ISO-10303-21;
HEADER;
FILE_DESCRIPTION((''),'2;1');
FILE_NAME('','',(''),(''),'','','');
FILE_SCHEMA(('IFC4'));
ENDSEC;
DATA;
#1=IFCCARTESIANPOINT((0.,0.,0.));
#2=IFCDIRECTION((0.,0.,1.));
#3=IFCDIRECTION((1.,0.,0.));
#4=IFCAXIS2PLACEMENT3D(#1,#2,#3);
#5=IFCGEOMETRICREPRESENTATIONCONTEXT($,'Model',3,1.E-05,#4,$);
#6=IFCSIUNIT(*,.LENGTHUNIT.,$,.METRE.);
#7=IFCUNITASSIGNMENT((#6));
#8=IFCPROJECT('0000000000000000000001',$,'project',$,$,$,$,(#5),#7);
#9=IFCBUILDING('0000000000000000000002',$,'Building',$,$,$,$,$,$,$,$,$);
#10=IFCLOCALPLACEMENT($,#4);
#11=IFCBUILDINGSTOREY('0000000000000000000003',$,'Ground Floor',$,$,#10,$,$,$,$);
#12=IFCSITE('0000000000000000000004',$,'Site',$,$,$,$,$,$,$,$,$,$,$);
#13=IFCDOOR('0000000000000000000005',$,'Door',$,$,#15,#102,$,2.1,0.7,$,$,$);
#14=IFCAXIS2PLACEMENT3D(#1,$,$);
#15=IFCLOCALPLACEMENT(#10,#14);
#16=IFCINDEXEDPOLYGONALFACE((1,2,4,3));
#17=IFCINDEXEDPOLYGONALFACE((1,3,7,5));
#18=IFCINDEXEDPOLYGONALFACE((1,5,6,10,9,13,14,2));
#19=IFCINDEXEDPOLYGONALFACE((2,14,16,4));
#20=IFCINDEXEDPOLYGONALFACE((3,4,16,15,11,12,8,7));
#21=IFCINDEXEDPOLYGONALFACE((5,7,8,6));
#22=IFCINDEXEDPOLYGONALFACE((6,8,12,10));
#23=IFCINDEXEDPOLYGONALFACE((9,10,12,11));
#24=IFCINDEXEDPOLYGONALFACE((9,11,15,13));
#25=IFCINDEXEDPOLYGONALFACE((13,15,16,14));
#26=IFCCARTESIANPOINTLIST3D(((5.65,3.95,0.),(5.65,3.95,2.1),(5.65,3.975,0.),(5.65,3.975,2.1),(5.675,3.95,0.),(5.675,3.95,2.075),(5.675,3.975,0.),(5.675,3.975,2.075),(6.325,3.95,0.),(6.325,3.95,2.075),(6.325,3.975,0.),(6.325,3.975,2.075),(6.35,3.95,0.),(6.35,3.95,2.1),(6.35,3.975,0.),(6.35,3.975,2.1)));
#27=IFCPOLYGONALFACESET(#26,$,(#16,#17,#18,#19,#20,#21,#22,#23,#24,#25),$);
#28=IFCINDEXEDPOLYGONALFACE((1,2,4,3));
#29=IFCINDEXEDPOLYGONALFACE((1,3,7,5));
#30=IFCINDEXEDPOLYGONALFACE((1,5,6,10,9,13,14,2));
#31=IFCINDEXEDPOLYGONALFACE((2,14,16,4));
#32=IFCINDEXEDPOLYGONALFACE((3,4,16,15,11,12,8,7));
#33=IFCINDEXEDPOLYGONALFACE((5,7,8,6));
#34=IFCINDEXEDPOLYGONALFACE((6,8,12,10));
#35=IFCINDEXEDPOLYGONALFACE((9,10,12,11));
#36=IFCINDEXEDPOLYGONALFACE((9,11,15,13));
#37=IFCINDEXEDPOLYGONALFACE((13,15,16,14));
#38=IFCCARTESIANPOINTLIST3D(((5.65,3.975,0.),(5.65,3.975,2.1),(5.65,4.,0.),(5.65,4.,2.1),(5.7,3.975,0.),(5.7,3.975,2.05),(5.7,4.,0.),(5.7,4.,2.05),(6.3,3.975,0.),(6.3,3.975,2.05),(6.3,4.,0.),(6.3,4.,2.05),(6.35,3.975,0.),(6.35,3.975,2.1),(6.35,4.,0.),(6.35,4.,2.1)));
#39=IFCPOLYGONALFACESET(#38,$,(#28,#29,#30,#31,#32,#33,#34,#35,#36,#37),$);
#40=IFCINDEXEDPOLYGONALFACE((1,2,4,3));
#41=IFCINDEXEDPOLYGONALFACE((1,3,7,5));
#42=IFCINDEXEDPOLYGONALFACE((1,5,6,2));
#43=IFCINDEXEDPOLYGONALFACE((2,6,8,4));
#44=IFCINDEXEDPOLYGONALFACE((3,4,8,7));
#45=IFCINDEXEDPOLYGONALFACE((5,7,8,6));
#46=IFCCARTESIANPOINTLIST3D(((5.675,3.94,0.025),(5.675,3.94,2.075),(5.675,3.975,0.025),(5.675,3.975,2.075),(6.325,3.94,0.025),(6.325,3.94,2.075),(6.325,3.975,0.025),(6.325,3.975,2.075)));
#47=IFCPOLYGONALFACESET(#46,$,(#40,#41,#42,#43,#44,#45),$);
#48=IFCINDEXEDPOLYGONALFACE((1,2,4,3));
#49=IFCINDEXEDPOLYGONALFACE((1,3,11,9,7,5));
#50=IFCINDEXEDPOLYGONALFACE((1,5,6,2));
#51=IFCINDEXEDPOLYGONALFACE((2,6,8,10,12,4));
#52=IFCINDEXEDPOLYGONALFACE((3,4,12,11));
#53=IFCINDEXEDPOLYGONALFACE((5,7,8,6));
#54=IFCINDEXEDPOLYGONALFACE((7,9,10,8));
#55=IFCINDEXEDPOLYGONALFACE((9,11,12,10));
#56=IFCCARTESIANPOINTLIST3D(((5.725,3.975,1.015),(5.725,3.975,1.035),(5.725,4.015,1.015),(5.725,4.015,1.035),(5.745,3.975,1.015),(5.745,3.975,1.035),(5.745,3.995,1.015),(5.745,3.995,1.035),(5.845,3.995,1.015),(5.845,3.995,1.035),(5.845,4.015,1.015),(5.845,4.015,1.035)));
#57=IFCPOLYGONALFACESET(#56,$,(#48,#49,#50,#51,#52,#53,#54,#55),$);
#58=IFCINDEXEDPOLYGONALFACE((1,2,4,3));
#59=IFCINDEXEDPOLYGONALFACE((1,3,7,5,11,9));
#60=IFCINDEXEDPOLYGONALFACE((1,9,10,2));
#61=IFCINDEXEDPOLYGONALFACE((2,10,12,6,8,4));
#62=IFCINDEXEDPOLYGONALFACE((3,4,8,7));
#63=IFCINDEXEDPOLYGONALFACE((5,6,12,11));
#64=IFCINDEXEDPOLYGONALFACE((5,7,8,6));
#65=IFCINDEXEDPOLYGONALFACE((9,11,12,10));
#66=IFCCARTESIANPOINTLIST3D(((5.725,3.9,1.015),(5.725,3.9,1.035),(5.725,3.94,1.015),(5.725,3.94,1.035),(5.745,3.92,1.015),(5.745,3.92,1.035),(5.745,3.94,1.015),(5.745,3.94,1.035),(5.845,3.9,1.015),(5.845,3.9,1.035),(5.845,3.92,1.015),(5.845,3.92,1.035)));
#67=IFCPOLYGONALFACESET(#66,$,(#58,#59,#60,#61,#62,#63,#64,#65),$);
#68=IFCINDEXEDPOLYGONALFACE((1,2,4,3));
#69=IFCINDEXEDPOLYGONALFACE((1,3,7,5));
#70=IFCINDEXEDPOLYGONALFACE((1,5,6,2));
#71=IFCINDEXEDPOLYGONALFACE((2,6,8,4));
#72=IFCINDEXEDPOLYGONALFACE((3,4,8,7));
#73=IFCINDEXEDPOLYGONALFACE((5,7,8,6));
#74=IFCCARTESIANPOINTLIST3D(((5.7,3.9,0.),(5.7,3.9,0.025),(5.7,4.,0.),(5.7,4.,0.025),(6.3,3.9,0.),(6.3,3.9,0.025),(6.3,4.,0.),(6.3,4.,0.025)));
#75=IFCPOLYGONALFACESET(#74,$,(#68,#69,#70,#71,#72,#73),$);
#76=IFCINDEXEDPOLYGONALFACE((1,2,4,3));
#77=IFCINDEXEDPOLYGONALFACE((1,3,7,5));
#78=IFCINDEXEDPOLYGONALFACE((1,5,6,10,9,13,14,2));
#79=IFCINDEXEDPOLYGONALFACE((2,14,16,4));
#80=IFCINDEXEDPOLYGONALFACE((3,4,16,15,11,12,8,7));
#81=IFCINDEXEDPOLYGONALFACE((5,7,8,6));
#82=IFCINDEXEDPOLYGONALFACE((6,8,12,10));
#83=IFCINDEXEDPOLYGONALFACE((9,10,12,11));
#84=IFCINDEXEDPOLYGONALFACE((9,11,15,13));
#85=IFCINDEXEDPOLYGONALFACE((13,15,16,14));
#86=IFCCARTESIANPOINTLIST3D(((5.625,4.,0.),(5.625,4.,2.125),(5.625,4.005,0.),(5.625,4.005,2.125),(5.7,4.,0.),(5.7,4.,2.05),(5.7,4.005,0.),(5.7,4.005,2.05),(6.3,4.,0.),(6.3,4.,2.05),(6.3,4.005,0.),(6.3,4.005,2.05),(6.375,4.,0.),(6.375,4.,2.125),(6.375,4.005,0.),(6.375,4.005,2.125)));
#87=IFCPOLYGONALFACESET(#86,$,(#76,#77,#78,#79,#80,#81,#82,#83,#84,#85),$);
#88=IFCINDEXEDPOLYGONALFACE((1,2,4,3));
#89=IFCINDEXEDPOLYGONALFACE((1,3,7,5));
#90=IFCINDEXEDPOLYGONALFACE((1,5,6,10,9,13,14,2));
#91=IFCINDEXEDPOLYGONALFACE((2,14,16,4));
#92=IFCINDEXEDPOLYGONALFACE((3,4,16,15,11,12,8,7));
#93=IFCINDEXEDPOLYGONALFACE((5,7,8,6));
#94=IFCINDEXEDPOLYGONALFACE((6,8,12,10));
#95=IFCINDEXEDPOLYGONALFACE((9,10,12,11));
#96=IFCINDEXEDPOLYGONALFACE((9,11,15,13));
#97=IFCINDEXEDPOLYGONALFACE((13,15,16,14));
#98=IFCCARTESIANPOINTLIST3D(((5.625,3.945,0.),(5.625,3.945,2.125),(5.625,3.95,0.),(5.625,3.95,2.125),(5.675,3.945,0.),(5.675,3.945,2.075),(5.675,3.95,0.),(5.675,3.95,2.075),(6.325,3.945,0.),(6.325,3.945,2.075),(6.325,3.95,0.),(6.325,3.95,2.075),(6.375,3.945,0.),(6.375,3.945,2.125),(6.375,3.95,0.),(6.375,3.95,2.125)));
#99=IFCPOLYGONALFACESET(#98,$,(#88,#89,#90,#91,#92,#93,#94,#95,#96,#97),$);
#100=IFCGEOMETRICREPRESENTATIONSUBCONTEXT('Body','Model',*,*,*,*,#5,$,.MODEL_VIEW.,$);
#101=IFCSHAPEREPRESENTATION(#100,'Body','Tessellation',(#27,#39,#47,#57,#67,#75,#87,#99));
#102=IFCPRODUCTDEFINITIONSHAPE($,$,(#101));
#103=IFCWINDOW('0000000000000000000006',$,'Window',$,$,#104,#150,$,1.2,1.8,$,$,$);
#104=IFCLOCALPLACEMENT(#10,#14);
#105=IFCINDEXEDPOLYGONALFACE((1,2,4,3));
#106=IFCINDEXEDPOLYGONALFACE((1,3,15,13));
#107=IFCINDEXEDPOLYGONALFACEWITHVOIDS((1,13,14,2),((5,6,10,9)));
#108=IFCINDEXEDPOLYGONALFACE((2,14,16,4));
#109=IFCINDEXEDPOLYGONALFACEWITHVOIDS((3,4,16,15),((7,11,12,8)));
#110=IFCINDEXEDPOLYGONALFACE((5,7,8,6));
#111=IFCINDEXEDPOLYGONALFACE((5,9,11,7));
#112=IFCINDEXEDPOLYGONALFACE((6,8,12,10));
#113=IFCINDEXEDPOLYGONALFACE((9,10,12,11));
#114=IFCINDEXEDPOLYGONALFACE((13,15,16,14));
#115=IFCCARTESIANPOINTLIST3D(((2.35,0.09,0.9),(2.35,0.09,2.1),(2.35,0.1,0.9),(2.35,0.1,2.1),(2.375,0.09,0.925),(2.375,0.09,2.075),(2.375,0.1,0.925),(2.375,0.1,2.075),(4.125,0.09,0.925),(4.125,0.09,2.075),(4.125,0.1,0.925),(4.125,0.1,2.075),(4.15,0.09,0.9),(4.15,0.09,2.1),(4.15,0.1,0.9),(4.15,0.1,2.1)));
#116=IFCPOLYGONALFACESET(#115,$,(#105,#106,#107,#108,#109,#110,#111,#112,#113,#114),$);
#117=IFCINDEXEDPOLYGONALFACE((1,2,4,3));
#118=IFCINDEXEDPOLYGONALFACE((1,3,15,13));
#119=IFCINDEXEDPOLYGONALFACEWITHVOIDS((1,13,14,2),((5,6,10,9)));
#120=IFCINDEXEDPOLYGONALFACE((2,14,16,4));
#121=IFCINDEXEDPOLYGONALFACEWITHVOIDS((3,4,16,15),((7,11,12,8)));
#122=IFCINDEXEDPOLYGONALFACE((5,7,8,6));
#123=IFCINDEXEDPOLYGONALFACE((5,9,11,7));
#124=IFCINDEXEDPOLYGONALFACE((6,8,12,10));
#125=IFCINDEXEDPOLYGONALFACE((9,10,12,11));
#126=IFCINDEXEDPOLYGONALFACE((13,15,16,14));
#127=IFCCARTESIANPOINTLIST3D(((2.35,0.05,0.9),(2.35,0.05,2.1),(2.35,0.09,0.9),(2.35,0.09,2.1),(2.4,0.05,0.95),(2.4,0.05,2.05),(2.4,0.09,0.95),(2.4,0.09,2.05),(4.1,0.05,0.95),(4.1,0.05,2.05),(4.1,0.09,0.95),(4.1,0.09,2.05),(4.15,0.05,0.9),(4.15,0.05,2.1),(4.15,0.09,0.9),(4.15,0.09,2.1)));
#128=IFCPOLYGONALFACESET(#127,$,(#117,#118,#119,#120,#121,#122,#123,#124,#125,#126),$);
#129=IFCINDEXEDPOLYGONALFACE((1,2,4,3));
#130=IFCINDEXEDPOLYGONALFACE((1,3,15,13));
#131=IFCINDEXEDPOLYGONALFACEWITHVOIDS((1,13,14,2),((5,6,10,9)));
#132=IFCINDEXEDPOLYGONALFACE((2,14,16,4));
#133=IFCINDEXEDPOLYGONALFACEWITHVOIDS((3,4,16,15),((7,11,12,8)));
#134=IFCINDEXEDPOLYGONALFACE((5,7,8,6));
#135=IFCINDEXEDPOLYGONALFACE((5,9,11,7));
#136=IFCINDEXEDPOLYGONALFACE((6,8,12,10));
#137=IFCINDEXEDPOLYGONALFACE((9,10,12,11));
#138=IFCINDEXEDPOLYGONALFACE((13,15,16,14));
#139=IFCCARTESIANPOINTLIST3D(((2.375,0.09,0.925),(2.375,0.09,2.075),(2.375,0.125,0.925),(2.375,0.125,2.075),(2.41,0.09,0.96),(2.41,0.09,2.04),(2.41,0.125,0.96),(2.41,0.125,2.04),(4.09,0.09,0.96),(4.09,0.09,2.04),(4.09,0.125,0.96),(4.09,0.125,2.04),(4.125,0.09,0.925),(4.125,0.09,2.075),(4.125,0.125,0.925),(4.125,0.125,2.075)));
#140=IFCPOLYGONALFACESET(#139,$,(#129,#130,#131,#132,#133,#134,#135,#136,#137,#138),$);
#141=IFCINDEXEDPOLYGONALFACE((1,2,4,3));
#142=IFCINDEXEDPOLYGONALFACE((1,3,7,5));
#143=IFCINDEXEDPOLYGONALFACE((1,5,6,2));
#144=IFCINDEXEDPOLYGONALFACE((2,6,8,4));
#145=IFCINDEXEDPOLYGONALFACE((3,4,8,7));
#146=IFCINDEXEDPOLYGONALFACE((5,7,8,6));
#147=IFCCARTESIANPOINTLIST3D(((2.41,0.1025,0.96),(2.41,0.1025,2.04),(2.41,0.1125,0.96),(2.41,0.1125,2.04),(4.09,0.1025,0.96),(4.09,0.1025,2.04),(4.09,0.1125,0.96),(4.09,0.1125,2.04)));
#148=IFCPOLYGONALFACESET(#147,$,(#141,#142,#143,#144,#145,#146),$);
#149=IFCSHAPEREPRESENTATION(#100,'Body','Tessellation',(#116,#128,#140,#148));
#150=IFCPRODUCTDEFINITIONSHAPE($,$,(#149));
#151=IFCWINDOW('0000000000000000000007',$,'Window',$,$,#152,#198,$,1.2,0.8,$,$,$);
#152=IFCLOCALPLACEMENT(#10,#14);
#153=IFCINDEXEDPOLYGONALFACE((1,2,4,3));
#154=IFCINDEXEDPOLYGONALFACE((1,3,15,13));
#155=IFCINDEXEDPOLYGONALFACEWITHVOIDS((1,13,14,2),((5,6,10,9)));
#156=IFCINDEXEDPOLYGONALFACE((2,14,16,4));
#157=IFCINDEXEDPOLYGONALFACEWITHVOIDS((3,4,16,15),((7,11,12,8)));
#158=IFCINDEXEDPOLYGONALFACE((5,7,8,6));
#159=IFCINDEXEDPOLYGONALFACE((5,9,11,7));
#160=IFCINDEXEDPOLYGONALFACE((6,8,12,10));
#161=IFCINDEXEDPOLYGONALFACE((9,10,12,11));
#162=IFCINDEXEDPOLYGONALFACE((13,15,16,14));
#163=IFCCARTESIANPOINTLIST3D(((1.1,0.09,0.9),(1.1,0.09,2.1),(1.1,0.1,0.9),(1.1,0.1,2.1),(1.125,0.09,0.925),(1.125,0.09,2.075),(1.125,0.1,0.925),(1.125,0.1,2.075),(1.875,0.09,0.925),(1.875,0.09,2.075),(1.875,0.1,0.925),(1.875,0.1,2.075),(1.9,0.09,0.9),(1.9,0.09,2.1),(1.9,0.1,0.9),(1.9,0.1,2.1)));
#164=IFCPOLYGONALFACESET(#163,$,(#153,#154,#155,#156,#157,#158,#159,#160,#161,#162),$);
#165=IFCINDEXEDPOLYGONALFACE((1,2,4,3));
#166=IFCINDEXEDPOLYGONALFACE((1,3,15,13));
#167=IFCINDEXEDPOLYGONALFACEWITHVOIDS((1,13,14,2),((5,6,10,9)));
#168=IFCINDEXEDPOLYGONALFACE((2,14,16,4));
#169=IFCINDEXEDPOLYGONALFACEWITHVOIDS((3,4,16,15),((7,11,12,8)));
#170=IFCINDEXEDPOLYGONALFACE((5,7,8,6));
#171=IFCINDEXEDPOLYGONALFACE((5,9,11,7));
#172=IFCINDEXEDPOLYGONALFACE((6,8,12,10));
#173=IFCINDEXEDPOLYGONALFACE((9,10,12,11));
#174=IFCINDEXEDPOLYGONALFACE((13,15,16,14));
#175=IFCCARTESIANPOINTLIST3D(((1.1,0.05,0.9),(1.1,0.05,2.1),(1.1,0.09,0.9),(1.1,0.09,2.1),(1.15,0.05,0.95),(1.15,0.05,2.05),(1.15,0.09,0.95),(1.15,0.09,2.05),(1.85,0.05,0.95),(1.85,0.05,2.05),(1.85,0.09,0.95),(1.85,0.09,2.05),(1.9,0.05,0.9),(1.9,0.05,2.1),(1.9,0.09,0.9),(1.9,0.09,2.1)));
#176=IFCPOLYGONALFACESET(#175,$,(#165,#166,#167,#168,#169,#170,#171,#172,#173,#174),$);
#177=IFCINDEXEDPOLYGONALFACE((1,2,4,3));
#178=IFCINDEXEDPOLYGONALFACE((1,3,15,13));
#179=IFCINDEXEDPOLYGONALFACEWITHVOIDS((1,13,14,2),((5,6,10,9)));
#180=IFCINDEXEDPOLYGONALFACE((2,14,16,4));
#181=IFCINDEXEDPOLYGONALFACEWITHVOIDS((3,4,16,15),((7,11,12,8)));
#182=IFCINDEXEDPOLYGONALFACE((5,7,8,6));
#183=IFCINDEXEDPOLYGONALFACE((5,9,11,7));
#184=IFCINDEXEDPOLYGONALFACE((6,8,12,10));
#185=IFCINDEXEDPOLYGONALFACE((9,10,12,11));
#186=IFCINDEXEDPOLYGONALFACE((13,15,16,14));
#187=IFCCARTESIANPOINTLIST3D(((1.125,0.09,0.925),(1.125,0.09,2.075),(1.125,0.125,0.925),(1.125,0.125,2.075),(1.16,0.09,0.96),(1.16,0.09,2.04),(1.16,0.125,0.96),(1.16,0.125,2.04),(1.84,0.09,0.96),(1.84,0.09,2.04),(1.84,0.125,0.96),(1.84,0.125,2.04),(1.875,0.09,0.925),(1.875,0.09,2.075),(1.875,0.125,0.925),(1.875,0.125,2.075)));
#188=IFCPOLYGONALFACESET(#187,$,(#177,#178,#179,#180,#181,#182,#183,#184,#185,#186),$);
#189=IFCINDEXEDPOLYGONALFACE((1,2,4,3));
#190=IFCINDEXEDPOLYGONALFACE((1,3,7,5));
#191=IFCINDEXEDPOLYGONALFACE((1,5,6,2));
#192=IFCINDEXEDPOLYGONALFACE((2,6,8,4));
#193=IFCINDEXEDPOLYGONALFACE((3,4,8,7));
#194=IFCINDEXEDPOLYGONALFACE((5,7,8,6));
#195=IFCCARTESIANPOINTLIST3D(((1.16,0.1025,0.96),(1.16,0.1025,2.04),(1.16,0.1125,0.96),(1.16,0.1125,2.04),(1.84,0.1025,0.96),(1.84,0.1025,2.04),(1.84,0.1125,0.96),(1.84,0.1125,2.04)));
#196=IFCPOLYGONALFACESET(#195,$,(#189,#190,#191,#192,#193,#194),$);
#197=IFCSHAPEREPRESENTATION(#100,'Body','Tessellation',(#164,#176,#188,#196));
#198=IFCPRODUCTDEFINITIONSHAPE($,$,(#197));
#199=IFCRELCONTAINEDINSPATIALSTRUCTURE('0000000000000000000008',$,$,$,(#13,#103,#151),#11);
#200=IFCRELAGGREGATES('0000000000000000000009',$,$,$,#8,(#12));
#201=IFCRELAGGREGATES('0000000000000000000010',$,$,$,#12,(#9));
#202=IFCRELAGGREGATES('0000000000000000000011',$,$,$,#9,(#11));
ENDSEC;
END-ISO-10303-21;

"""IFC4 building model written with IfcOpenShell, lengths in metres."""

from ifc_helpers import new_model, si_unit, frame, origin_with_axes, place, context, subcontext, project, spatial, line, indexed_curve, outline, extrude, element, save


model = new_model("IFC4")

# Units and contexts
model_context = context("Model", 3, precision=1e-05, world=origin_with_axes())
body_context = subcontext(model_context, "Body", "Model", "MODEL_VIEW")
ifc_project = project(units=[si_unit("LENGTHUNIT", "METRE")], contexts=[model_context])

# Site, building, storey
site = spatial("IfcSite", under=ifc_project, Name="Site")
building = spatial("IfcBuilding", under=site, Name="Building")
storey_placement = place(None, origin_with_axes())
storey = spatial("IfcBuildingStorey", under=building, at=storey_placement, Name="Ground Floor")

# Door
door_1_placement = place(storey_placement, frame((6.35, 4.0, 0.0), z_axis=(0.0, 0.0, 1.0), x_axis=(-1.0, 0.0, 0.0)))
element("IfcDoor", 1, at=door_1_placement, inside=storey, Name="Door", OverallHeight=2.1, OverallWidth=0.7, context=body_context, shape_type="SweptSolid", body=[
    extrude(outline(indexed_curve([(0.0, 0.0), (0.0, 2.1), (0.7, 2.1), (0.7, 0.0), (0.675, 0.0), (0.675, 2.075), (0.025, 2.075), (0.025, 0.0)], segments=[line(1, 2, 3, 4, 5, 6, 7, 8, 1)])), frame((0.0, 0.025, 0.0), z_axis=(0.0, -1.0, 0.0), x_axis=(1.0, 0.0, 0.0)), (0.0, 0.0, -1.0), 0.025),
    extrude(outline(indexed_curve([(0.0, 0.0), (0.0, 2.1), (0.7, 2.1), (0.7, 0.0), (0.65, 0.0), (0.65, 2.05), (0.05, 2.05), (0.05, 0.0)], segments=[line(1, 2, 3, 4, 5, 6, 7, 8, 1)])), frame((0.0, 0.0, 0.0), z_axis=(0.0, -1.0, 0.0), x_axis=(1.0, 0.0, 0.0)), (0.0, 0.0, -1.0), 0.025),
    extrude(outline(indexed_curve([(0.0, 0.0), (0.65, 0.0), (0.65, 0.035), (0.0, 0.035)], segments=[line(1, 2, 3, 4, 1)])), frame((0.025, 0.025, 0.025), z_axis=(0.0, 0.0, 1.0), x_axis=(1.0, 0.0, 0.0)), (0.0, 0.0, 1.0), 2.05),
    extrude(outline(indexed_curve([(0.0, 0.0), (0.0, -0.04), (-0.12, -0.04), (-0.12, -0.02), (-0.02, -0.02), (-0.02, 0.0)], segments=[line(1, 2, 3, 4, 5, 6, 1)])), frame((0.625, 0.025, 1.015), z_axis=(0.0, 0.0, 1.0), x_axis=(1.0, 0.0, 0.0)), (0.0, 0.0, 1.0), 0.02),
    extrude(outline(indexed_curve([(0.0, 0.0), (0.0, 0.04), (-0.12, 0.04), (-0.12, 0.02), (-0.02, 0.02), (-0.02, 0.0)], segments=[line(1, 2, 3, 4, 5, 6, 1)])), frame((0.625, 0.06, 1.015), z_axis=(0.0, 0.0, 1.0), x_axis=(1.0, 0.0, 0.0)), (0.0, 0.0, 1.0), 0.02),
    extrude(outline(indexed_curve([(0.0, 0.0), (0.6, 0.0), (0.6, 0.1), (0.0, 0.1)], segments=[line(1, 2, 3, 4, 1)])), frame((0.05, 0.0, 0.0), z_axis=(0.0, 0.0, 1.0), x_axis=(1.0, 0.0, 0.0)), (0.0, 0.0, 1.0), 0.025),
    extrude(outline(indexed_curve([(0.0, 0.0), (0.0, 2.125), (0.75, 2.125), (0.75, 0.0), (0.675, 0.0), (0.675, 2.05), (0.075, 2.05), (0.075, 0.0)], segments=[line(1, 2, 3, 4, 5, 6, 7, 8, 1)])), frame((-0.025, -0.005, 0.0), z_axis=(0.0, -1.0, 0.0), x_axis=(1.0, 0.0, 0.0)), (0.0, 0.0, -1.0), 0.005),
    extrude(outline(indexed_curve([(0.0, 0.0), (0.0, 2.125), (0.75, 2.125), (0.75, 0.0), (0.7, 0.0), (0.7, 2.075), (0.05, 2.075), (0.05, 0.0)], segments=[line(1, 2, 3, 4, 5, 6, 7, 8, 1)])), frame((-0.025, 0.05, 0.0), z_axis=(0.0, -1.0, 0.0), x_axis=(1.0, 0.0, 0.0)), (0.0, 0.0, -1.0), 0.005),
])

# Windows
window_1_placement = place(storey_placement, frame((2.35, 0.0, 0.9), z_axis=(0.0, 0.0, 1.0), x_axis=(1.0, 0.0, 0.0)))
element("IfcWindow", 2, at=window_1_placement, inside=storey, Name="Window", OverallHeight=1.2, OverallWidth=1.8, context=body_context, shape_type="SweptSolid", body=[
    extrude(outline(indexed_curve([(0.0, 0.0), (1.8, 0.0), (1.8, 1.2), (0.0, 1.2)], segments=[line(1, 2, 3, 4, 1)]), holes=[indexed_curve([(0.025, 0.025), (1.775, 0.025), (1.775, 1.175), (0.025, 1.175)], segments=[line(1, 2, 3, 4, 1)])]), frame((0.0, 0.09, 0.0), z_axis=(0.0, -1.0, 0.0), x_axis=(1.0, 0.0, 0.0)), (0.0, 0.0, -1.0), 0.01),
    extrude(outline(indexed_curve([(0.0, 0.0), (1.8, 0.0), (1.8, 1.2), (0.0, 1.2)], segments=[line(1, 2, 3, 4, 1)]), holes=[indexed_curve([(0.05, 0.05), (1.75, 0.05), (1.75, 1.15), (0.05, 1.15)], segments=[line(1, 2, 3, 4, 1)])]), frame((0.0, 0.05, 0.0), z_axis=(0.0, -1.0, 0.0), x_axis=(1.0, 0.0, 0.0)), (0.0, 0.0, -1.0), 0.04),
    extrude(outline(indexed_curve([(0.0, 0.0), (1.75, 0.0), (1.75, 1.15), (0.0, 1.15)], segments=[line(1, 2, 3, 4, 1)]), holes=[indexed_curve([(0.035, 0.035), (1.715, 0.035), (1.715, 1.115), (0.035, 1.115)], segments=[line(1, 2, 3, 4, 1)])]), frame((0.025, 0.09, 0.025), z_axis=(0.0, -1.0, 0.0), x_axis=(1.0, 0.0, 0.0)), (0.0, 0.0, -1.0), 0.035),
    extrude(outline(indexed_curve([(0.035, 0.035), (1.715, 0.035), (1.715, 1.115), (0.035, 1.115)], segments=[line(1, 2, 3, 4, 1)])), frame((0.025, 0.1025, 0.025), z_axis=(0.0, -1.0, 0.0), x_axis=(1.0, 0.0, 0.0)), (0.0, 0.0, -1.0), 0.01),
])
window_2_placement = place(storey_placement, frame((1.1, 0.0, 0.9), z_axis=(0.0, 0.0, 1.0), x_axis=(1.0, 0.0, 0.0)))
element("IfcWindow", 3, at=window_2_placement, inside=storey, Name="Window", OverallHeight=1.2, OverallWidth=0.8, context=body_context, shape_type="SweptSolid", body=[
    extrude(outline(indexed_curve([(0.0, 0.0), (0.8, 0.0), (0.8, 1.2), (0.0, 1.2)], segments=[line(1, 2, 3, 4, 1)]), holes=[indexed_curve([(0.025, 0.025), (0.775, 0.025), (0.775, 1.175), (0.025, 1.175)], segments=[line(1, 2, 3, 4, 1)])]), frame((0.0, 0.09, 0.0), z_axis=(0.0, -1.0, 0.0), x_axis=(1.0, 0.0, 0.0)), (0.0, 0.0, -1.0), 0.01),
    extrude(outline(indexed_curve([(0.0, 0.0), (0.8, 0.0), (0.8, 1.2), (0.0, 1.2)], segments=[line(1, 2, 3, 4, 1)]), holes=[indexed_curve([(0.05, 0.05), (0.75, 0.05), (0.75, 1.15), (0.05, 1.15)], segments=[line(1, 2, 3, 4, 1)])]), frame((0.0, 0.05, 0.0), z_axis=(0.0, -1.0, 0.0), x_axis=(1.0, 0.0, 0.0)), (0.0, 0.0, -1.0), 0.04),
    extrude(outline(indexed_curve([(0.0, 0.0), (0.75, 0.0), (0.75, 1.15), (0.0, 1.15)], segments=[line(1, 2, 3, 4, 1)]), holes=[indexed_curve([(0.035, 0.035), (0.715, 0.035), (0.715, 1.115), (0.035, 1.115)], segments=[line(1, 2, 3, 4, 1)])]), frame((0.025, 0.09, 0.025), z_axis=(0.0, -1.0, 0.0), x_axis=(1.0, 0.0, 0.0)), (0.0, 0.0, -1.0), 0.035),
    extrude(outline(indexed_curve([(0.035, 0.035), (0.715, 0.035), (0.715, 1.115), (0.035, 1.115)], segments=[line(1, 2, 3, 4, 1)])), frame((0.025, 0.1025, 0.025), z_axis=(0.0, -1.0, 0.0), x_axis=(1.0, 0.0, 0.0)), (0.0, 0.0, -1.0), 0.01),
])

save(model, "model.ifc")
